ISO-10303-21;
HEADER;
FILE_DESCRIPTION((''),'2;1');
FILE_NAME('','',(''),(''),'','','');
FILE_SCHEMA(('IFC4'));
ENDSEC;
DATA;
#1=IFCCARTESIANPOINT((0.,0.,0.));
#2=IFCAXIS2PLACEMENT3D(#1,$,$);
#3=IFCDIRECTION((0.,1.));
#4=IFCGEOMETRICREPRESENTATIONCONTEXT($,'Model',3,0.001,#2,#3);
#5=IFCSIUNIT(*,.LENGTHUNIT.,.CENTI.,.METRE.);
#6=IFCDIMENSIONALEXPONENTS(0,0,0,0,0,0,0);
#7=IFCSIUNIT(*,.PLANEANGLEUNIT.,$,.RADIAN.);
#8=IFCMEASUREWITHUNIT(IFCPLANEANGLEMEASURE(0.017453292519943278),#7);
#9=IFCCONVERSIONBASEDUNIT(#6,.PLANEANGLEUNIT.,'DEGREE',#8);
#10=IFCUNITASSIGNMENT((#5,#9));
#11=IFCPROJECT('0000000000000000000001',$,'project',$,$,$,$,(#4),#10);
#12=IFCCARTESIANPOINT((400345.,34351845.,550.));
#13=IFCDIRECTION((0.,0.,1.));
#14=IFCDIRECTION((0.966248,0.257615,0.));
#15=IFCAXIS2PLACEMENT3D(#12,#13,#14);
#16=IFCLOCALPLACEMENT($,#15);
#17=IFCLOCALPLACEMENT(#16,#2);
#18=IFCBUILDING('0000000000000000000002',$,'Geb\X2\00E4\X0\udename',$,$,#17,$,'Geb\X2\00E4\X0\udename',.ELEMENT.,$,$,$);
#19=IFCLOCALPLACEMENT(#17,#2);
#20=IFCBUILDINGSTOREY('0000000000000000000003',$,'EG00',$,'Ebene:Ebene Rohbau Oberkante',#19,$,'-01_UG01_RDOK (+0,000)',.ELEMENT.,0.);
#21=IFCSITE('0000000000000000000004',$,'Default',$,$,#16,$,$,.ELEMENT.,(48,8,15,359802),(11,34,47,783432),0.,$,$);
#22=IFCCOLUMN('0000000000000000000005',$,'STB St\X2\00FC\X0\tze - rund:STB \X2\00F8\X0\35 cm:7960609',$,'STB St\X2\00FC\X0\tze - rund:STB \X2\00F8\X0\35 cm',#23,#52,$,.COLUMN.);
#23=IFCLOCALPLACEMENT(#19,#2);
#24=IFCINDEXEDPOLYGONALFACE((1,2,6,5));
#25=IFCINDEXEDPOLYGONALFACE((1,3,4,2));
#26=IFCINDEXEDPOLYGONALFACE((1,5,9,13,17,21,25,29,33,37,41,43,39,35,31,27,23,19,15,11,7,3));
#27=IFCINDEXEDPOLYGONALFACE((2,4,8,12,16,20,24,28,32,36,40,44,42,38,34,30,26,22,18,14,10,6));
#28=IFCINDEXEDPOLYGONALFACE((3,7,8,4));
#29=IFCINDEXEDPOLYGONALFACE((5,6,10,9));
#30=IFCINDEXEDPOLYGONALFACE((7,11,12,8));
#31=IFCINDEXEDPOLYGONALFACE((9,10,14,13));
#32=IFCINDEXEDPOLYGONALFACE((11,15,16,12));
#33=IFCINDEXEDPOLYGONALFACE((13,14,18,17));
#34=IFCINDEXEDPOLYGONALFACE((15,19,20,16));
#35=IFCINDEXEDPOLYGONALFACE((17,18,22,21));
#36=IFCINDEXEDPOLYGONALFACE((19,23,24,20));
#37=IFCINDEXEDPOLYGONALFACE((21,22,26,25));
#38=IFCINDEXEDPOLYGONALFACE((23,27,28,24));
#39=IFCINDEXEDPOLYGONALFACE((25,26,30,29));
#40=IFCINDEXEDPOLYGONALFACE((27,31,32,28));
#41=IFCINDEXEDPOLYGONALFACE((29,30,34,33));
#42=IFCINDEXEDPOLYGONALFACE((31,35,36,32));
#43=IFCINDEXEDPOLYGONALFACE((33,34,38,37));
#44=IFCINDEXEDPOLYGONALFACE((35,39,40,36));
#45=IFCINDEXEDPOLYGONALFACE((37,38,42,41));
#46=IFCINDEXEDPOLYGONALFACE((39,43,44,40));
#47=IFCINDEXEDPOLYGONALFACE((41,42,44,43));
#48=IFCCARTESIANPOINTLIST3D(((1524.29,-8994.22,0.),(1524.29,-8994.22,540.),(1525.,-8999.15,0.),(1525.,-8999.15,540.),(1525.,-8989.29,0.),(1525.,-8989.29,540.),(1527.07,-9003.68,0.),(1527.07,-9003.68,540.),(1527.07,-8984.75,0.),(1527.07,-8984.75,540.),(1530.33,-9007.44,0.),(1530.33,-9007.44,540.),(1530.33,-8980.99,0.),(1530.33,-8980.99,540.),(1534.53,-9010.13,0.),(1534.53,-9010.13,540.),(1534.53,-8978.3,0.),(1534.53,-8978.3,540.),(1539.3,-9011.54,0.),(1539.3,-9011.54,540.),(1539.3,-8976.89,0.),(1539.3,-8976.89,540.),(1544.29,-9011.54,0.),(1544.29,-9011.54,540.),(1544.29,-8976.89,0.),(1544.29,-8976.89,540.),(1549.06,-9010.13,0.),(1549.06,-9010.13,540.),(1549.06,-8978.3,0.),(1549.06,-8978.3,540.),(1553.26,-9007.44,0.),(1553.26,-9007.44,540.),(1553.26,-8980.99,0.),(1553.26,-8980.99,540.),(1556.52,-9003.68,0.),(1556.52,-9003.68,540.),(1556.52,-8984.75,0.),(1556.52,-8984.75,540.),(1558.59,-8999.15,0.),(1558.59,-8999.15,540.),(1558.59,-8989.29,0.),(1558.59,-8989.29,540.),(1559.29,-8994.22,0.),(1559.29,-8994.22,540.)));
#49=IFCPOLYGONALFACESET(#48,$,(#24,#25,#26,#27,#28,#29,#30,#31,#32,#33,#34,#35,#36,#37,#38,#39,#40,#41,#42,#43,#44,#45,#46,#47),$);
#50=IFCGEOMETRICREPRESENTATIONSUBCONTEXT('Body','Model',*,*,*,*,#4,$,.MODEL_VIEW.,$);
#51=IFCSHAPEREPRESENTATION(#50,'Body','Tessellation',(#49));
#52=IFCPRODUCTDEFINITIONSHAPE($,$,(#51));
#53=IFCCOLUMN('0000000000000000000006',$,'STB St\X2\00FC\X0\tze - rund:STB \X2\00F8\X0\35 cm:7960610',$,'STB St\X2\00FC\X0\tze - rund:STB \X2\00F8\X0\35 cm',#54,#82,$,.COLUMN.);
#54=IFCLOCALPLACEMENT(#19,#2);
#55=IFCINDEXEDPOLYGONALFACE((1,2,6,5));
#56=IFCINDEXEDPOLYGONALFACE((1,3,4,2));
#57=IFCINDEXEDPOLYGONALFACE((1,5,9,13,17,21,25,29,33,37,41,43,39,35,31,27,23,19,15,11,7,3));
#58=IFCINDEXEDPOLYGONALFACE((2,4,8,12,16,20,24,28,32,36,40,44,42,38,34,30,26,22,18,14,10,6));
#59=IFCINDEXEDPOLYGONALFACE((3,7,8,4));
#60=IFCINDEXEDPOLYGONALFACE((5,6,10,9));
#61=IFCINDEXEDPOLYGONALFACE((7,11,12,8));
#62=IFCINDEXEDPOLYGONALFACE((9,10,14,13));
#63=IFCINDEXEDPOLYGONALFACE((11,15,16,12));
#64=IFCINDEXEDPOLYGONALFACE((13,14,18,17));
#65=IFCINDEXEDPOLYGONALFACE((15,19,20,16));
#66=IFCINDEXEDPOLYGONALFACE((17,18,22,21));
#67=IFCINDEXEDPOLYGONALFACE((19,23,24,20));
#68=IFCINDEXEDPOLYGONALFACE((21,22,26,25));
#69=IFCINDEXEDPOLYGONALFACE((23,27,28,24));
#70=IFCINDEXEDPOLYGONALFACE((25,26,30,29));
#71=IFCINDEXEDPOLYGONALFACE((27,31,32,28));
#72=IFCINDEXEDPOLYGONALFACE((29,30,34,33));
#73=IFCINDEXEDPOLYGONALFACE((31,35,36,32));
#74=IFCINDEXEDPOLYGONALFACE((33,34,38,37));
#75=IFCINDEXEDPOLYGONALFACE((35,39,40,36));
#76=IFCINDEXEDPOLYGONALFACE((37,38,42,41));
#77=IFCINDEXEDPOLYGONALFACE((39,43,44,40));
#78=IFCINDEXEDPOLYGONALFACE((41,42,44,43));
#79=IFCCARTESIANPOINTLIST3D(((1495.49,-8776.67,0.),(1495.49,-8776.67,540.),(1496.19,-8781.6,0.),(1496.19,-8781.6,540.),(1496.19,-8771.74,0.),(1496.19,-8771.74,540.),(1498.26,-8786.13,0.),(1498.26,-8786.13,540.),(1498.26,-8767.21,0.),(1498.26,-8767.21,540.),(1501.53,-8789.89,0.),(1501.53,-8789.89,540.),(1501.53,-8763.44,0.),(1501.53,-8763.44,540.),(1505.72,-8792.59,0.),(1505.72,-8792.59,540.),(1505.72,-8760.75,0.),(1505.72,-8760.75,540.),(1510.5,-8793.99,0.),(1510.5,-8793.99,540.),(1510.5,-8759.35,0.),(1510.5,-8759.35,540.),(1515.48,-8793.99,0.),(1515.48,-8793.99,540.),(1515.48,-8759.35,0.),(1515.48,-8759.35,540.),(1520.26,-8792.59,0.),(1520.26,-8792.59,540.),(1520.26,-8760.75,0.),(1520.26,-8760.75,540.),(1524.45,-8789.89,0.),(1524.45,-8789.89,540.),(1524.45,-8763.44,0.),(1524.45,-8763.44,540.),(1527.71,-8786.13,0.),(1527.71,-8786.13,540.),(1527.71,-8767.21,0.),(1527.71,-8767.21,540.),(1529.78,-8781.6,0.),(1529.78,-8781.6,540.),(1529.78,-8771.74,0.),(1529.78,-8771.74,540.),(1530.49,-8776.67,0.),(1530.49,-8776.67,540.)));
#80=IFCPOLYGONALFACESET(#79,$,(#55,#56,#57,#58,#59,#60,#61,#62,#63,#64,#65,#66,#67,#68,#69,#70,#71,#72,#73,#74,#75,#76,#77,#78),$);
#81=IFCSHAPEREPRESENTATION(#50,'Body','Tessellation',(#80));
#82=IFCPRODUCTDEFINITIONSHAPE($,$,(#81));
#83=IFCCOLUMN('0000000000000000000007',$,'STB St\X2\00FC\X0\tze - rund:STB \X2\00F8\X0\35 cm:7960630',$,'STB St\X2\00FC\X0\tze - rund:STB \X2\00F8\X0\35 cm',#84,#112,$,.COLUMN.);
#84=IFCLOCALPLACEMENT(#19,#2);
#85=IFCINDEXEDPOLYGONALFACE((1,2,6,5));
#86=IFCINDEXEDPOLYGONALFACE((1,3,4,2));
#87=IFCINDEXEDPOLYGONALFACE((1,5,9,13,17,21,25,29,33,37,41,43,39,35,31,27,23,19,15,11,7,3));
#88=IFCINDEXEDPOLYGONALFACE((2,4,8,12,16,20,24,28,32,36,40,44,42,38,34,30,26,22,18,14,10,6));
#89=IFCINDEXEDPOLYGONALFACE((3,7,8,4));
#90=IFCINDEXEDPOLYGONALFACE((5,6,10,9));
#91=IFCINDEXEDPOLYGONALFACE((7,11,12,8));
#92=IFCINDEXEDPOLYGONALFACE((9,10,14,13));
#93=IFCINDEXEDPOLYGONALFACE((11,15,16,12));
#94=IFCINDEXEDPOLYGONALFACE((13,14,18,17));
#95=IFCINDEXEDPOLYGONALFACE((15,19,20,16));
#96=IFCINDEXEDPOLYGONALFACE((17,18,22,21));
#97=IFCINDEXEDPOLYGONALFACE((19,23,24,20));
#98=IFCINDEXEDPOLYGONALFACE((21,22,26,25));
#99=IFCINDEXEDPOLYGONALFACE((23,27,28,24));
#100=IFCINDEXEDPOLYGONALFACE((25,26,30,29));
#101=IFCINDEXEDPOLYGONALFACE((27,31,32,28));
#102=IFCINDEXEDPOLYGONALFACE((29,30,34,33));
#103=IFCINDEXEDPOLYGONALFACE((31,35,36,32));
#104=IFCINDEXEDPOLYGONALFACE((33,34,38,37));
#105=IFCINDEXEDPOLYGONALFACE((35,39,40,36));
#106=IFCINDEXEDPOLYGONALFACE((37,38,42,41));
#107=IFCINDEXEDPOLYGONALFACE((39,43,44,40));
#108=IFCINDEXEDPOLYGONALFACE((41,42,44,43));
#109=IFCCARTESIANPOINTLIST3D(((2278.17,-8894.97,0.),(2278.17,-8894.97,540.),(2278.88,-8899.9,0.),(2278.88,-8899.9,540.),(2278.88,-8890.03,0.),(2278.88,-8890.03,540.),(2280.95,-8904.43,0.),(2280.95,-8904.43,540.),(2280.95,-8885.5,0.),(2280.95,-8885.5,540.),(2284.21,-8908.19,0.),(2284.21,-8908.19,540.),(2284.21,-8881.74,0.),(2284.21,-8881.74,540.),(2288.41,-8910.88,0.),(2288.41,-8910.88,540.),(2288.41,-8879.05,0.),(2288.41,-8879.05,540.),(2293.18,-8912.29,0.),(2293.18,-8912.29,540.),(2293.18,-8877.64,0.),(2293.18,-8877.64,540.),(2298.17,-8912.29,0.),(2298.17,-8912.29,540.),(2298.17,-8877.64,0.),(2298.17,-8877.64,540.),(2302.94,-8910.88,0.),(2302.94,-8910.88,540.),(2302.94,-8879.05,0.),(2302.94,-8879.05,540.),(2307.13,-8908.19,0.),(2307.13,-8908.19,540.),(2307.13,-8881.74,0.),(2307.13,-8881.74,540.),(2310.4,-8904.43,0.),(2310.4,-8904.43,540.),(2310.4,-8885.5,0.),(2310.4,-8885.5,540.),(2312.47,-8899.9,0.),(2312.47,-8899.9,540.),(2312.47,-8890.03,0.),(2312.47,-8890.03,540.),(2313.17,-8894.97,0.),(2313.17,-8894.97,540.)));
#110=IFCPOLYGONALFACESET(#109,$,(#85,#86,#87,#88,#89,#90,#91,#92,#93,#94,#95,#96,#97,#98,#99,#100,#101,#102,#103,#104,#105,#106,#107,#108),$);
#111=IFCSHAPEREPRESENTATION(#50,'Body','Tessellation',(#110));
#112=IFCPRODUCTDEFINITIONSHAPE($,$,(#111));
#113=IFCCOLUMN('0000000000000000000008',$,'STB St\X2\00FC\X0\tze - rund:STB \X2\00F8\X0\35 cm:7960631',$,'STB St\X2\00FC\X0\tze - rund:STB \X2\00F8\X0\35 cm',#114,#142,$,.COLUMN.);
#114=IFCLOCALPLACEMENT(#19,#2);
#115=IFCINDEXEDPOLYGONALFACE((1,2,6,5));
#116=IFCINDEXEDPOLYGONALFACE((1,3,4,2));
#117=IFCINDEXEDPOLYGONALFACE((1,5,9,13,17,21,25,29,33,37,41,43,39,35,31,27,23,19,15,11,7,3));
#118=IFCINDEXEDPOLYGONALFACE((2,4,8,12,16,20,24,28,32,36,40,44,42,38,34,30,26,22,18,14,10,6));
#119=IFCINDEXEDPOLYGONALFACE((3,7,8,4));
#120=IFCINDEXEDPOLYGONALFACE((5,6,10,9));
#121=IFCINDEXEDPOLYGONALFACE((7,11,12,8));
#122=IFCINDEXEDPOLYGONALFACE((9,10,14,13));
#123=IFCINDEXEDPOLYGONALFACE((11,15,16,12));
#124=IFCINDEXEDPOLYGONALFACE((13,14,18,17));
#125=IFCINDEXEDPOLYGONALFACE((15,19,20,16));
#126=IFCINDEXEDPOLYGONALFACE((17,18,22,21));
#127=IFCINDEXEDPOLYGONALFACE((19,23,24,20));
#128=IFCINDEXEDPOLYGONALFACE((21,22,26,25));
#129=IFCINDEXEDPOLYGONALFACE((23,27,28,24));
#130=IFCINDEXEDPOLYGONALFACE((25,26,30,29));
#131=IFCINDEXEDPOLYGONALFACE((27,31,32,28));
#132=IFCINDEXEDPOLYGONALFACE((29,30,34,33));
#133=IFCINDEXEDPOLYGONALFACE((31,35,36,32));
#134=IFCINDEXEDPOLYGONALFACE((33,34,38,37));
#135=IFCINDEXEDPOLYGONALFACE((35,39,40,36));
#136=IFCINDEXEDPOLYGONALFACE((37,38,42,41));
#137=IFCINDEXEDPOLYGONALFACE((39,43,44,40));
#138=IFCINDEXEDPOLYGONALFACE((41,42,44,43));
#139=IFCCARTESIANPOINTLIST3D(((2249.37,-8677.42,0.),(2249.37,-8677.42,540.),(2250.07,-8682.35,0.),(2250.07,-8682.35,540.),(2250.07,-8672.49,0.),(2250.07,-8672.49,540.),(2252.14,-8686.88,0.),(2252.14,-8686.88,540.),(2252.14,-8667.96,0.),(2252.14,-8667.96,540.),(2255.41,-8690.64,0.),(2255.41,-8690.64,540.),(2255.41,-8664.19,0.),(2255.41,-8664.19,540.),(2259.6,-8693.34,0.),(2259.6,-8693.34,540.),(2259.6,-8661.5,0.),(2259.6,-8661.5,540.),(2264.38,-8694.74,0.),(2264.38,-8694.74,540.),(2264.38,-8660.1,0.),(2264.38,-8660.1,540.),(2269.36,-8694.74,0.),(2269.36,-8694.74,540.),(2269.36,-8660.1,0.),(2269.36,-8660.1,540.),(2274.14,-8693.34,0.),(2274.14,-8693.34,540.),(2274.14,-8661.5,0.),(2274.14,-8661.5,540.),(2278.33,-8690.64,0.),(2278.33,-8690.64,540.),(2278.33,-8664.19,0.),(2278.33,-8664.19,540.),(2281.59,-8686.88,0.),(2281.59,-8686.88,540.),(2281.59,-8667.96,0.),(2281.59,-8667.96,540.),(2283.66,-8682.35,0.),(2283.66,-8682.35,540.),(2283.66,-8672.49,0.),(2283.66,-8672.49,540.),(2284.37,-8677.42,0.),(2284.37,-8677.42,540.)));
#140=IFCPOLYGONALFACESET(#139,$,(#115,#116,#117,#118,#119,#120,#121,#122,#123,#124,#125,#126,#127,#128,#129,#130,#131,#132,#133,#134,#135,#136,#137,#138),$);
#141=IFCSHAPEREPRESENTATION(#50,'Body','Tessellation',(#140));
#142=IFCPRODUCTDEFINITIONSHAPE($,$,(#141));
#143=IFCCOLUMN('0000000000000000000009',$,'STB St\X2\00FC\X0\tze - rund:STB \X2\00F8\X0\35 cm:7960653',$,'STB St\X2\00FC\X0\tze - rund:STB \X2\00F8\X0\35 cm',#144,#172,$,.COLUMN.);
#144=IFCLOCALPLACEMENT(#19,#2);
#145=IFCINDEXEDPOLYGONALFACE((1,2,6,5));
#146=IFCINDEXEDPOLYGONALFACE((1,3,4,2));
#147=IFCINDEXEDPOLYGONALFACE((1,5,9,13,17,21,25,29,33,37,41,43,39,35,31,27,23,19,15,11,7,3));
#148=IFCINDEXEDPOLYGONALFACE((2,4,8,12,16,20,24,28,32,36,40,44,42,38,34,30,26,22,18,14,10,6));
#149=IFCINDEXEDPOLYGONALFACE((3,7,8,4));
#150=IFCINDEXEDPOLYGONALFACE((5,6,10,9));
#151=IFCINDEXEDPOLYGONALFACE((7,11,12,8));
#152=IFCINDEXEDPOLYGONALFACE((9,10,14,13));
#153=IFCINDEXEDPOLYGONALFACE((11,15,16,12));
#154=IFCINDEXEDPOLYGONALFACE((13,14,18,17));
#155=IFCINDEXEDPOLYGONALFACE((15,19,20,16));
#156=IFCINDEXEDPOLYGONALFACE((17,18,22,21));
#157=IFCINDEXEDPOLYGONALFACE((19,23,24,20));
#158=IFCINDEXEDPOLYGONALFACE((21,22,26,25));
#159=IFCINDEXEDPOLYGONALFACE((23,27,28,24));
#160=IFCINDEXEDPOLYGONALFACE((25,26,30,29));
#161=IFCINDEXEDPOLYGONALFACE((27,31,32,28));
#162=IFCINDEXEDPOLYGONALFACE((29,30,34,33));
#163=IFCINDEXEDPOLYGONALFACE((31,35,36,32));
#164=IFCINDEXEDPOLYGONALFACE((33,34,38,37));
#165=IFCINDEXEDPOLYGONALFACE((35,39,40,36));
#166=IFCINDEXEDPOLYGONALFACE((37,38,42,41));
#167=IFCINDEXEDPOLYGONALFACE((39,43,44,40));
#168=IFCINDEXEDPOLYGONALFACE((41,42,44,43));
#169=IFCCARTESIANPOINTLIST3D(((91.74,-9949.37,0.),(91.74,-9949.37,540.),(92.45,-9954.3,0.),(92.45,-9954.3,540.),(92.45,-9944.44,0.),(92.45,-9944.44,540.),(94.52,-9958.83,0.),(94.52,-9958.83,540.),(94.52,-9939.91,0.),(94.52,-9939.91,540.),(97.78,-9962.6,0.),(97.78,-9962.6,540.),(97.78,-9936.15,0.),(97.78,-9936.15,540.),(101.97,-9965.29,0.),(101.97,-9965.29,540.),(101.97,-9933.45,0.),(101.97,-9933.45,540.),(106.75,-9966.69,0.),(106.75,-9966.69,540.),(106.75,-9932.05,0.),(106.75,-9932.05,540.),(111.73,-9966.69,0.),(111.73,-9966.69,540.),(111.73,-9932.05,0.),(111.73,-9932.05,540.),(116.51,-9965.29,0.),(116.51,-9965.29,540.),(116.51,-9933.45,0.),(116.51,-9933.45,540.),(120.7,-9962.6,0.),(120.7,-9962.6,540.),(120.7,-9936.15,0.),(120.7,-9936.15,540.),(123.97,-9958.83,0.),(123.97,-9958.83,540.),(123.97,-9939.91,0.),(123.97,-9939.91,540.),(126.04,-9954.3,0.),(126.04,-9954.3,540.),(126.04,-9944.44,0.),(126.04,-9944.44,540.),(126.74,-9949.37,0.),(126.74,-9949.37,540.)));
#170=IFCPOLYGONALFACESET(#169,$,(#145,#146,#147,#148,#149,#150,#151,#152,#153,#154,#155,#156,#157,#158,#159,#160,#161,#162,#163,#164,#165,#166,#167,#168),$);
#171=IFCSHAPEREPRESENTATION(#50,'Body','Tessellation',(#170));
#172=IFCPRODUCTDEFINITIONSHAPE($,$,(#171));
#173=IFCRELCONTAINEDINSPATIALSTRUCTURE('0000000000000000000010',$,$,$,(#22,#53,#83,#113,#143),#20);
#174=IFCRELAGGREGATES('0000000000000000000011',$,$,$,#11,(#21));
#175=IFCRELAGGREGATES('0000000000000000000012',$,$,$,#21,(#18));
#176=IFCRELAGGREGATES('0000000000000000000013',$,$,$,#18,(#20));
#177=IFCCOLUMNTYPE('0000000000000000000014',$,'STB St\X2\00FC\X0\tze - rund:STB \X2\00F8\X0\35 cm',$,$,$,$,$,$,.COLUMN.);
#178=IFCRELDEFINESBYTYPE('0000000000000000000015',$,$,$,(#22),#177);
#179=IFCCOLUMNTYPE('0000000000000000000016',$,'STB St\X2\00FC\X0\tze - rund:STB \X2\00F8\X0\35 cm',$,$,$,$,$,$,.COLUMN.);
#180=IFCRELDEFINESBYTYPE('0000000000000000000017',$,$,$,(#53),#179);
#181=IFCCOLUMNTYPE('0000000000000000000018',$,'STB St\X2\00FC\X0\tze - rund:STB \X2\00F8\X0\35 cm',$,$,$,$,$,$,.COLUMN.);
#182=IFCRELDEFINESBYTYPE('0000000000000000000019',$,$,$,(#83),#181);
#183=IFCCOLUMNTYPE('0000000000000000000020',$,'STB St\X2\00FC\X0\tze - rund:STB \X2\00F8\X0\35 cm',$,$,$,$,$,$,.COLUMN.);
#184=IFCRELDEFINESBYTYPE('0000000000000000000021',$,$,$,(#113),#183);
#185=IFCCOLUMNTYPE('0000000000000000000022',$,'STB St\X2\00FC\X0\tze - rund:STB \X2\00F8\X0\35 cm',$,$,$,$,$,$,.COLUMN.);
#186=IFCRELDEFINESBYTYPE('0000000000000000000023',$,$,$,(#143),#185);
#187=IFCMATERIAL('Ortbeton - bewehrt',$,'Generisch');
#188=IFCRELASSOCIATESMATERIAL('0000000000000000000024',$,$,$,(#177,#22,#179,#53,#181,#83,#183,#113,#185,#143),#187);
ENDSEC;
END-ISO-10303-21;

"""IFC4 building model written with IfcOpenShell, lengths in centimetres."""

from ifc_helpers import new_model, entity, si_unit, converted_unit, direction, frame, origin, place, context, subcontext, project, spatial, arc, indexed_curve, outline, extrude, source, transform, mapped, material, type_object, type_shapes, element, save


model = new_model("IFC4")

# Units and contexts
model_context = context("Model", 3, precision=0.001, world=origin(), true_north=direction((0.0, 1.0)))
body_context = subcontext(model_context, "Body", "Model", "MODEL_VIEW")
ifc_project = project(units=[si_unit("LENGTHUNIT", "METRE", prefix="CENTI"), converted_unit("PLANEANGLEUNIT", "DEGREE", entity("IfcPlaneAngleMeasure", 0.017453292519943278), si_unit("PLANEANGLEUNIT", "RADIAN"), dimensions=[0, 0, 0, 0, 0, 0, 0])], contexts=[model_context])

# Site, building, storey
site_placement = place(None, frame((400345.0, 34351845.0, 550.0), z_axis=(0.0, 0.0, 1.0), x_axis=(0.966248, 0.257615, 0.0)))
site = spatial("IfcSite", under=ifc_project, at=site_placement, Name="Default", CompositionType="ELEMENT", RefLatitude=(48, 8, 15, 359802), RefLongitude=(11, 34, 47, 783432), RefElevation=0.0)
building_placement = place(site_placement, origin())
building = spatial("IfcBuilding", under=site, at=building_placement, Name="Gebäudename", LongName="Gebäudename", CompositionType="ELEMENT")
storey_placement = place(building_placement, origin())
storey = spatial("IfcBuildingStorey", under=building, at=storey_placement, Name="EG00", ObjectType="Ebene:Ebene Rohbau Oberkante", LongName="-01_UG01_RDOK (+0,000)", CompositionType="ELEMENT", Elevation=0.0)

# Columns
ifc_material = material(Name="Ortbeton - bewehrt", Category="Generisch")
column_type_1 = type_object("IfcColumnType", Name="STB Stütze - rund:STB ø35 cm", PredefinedType="COLUMN", material=ifc_material)
shared_shape_1 = source(origin(), body_context, "Body", "SweptSolid", [
    extrude(outline(indexed_curve([(-17.5, 0.0), (0.0, -17.5), (17.5, 0.0), (0.0, 17.5)], segments=[arc(1, 2, 3), arc(3, 4, 1)], self_intersect=False)), frame((1541.79, -8994.22, 0.0)), (0.0, 0.0, 1.0), 540.0),
])
type_shapes(column_type_1, [shared_shape_1])
column_1_placement = place(storey_placement, origin())
element("IfcColumn", 1, at=column_1_placement, inside=storey, type_object=column_type_1, material=ifc_material, Name="STB Stütze - rund:STB ø35 cm:7960609", ObjectType="STB Stütze - rund:STB ø35 cm", PredefinedType="COLUMN", context=body_context, shape_type="MappedRepresentation", body=[
    mapped(shared_shape_1, transform((0.0, 0.0, 0.0), scale=1.0)),
])
column_type_2 = type_object("IfcColumnType", Name="STB Stütze - rund:STB ø35 cm", PredefinedType="COLUMN", material=ifc_material)
shared_shape_2 = source(origin(), body_context, "Body", "SweptSolid", [
    extrude(outline(indexed_curve([(-17.5, 0.0), (0.0, -17.5), (17.5, 0.0), (0.0, 17.5)], segments=[arc(1, 2, 3), arc(3, 4, 1)], self_intersect=False)), frame((1512.99, -8776.67, 0.0)), (0.0, 0.0, 1.0), 540.0),
])
type_shapes(column_type_2, [shared_shape_2])
column_2_placement = place(storey_placement, origin())
element("IfcColumn", 2, at=column_2_placement, inside=storey, type_object=column_type_2, material=ifc_material, Name="STB Stütze - rund:STB ø35 cm:7960610", ObjectType="STB Stütze - rund:STB ø35 cm", PredefinedType="COLUMN", context=body_context, shape_type="MappedRepresentation", body=[
    mapped(shared_shape_2, transform((0.0, 0.0, 0.0), scale=1.0)),
])
column_type_3 = type_object("IfcColumnType", Name="STB Stütze - rund:STB ø35 cm", PredefinedType="COLUMN", material=ifc_material)
shared_shape_3 = source(origin(), body_context, "Body", "SweptSolid", [
    extrude(outline(indexed_curve([(-17.5, 0.0), (0.0, -17.5), (17.5, 0.0), (0.0, 17.5)], segments=[arc(1, 2, 3), arc(3, 4, 1)], self_intersect=False)), frame((2295.67, -8894.97, 0.0)), (0.0, 0.0, 1.0), 540.0),
])
type_shapes(column_type_3, [shared_shape_3])
column_3_placement = place(storey_placement, origin())
element("IfcColumn", 3, at=column_3_placement, inside=storey, type_object=column_type_3, material=ifc_material, Name="STB Stütze - rund:STB ø35 cm:7960630", ObjectType="STB Stütze - rund:STB ø35 cm", PredefinedType="COLUMN", context=body_context, shape_type="MappedRepresentation", body=[
    mapped(shared_shape_3, transform((0.0, 0.0, 0.0), scale=1.0)),
])
column_type_4 = type_object("IfcColumnType", Name="STB Stütze - rund:STB ø35 cm", PredefinedType="COLUMN", material=ifc_material)
shared_shape_4 = source(origin(), body_context, "Body", "SweptSolid", [
    extrude(outline(indexed_curve([(-17.5, 0.0), (0.0, -17.5), (17.5, 0.0), (0.0, 17.5)], segments=[arc(1, 2, 3), arc(3, 4, 1)], self_intersect=False)), frame((2266.87, -8677.42, 0.0)), (0.0, 0.0, 1.0), 540.0),
])
type_shapes(column_type_4, [shared_shape_4])
column_4_placement = place(storey_placement, origin())
element("IfcColumn", 4, at=column_4_placement, inside=storey, type_object=column_type_4, material=ifc_material, Name="STB Stütze - rund:STB ø35 cm:7960631", ObjectType="STB Stütze - rund:STB ø35 cm", PredefinedType="COLUMN", context=body_context, shape_type="MappedRepresentation", body=[
    mapped(shared_shape_4, transform((0.0, 0.0, 0.0), scale=1.0)),
])
column_type_5 = type_object("IfcColumnType", Name="STB Stütze - rund:STB ø35 cm", PredefinedType="COLUMN", material=ifc_material)
shared_shape_5 = source(origin(), body_context, "Body", "SweptSolid", [
    extrude(outline(indexed_curve([(-17.5, 0.0), (0.0, -17.5), (17.5, 0.0), (0.0, 17.5)], segments=[arc(1, 2, 3), arc(3, 4, 1)], self_intersect=False)), frame((109.24, -9949.37, 0.0)), (0.0, 0.0, 1.0), 540.0),
])
type_shapes(column_type_5, [shared_shape_5])
column_5_placement = place(storey_placement, origin())
element("IfcColumn", 5, at=column_5_placement, inside=storey, type_object=column_type_5, material=ifc_material, Name="STB Stütze - rund:STB ø35 cm:7960653", ObjectType="STB Stütze - rund:STB ø35 cm", PredefinedType="COLUMN", context=body_context, shape_type="MappedRepresentation", body=[
    mapped(shared_shape_5, transform((0.0, 0.0, 0.0), scale=1.0)),
])

save(model, "model.ifc")
